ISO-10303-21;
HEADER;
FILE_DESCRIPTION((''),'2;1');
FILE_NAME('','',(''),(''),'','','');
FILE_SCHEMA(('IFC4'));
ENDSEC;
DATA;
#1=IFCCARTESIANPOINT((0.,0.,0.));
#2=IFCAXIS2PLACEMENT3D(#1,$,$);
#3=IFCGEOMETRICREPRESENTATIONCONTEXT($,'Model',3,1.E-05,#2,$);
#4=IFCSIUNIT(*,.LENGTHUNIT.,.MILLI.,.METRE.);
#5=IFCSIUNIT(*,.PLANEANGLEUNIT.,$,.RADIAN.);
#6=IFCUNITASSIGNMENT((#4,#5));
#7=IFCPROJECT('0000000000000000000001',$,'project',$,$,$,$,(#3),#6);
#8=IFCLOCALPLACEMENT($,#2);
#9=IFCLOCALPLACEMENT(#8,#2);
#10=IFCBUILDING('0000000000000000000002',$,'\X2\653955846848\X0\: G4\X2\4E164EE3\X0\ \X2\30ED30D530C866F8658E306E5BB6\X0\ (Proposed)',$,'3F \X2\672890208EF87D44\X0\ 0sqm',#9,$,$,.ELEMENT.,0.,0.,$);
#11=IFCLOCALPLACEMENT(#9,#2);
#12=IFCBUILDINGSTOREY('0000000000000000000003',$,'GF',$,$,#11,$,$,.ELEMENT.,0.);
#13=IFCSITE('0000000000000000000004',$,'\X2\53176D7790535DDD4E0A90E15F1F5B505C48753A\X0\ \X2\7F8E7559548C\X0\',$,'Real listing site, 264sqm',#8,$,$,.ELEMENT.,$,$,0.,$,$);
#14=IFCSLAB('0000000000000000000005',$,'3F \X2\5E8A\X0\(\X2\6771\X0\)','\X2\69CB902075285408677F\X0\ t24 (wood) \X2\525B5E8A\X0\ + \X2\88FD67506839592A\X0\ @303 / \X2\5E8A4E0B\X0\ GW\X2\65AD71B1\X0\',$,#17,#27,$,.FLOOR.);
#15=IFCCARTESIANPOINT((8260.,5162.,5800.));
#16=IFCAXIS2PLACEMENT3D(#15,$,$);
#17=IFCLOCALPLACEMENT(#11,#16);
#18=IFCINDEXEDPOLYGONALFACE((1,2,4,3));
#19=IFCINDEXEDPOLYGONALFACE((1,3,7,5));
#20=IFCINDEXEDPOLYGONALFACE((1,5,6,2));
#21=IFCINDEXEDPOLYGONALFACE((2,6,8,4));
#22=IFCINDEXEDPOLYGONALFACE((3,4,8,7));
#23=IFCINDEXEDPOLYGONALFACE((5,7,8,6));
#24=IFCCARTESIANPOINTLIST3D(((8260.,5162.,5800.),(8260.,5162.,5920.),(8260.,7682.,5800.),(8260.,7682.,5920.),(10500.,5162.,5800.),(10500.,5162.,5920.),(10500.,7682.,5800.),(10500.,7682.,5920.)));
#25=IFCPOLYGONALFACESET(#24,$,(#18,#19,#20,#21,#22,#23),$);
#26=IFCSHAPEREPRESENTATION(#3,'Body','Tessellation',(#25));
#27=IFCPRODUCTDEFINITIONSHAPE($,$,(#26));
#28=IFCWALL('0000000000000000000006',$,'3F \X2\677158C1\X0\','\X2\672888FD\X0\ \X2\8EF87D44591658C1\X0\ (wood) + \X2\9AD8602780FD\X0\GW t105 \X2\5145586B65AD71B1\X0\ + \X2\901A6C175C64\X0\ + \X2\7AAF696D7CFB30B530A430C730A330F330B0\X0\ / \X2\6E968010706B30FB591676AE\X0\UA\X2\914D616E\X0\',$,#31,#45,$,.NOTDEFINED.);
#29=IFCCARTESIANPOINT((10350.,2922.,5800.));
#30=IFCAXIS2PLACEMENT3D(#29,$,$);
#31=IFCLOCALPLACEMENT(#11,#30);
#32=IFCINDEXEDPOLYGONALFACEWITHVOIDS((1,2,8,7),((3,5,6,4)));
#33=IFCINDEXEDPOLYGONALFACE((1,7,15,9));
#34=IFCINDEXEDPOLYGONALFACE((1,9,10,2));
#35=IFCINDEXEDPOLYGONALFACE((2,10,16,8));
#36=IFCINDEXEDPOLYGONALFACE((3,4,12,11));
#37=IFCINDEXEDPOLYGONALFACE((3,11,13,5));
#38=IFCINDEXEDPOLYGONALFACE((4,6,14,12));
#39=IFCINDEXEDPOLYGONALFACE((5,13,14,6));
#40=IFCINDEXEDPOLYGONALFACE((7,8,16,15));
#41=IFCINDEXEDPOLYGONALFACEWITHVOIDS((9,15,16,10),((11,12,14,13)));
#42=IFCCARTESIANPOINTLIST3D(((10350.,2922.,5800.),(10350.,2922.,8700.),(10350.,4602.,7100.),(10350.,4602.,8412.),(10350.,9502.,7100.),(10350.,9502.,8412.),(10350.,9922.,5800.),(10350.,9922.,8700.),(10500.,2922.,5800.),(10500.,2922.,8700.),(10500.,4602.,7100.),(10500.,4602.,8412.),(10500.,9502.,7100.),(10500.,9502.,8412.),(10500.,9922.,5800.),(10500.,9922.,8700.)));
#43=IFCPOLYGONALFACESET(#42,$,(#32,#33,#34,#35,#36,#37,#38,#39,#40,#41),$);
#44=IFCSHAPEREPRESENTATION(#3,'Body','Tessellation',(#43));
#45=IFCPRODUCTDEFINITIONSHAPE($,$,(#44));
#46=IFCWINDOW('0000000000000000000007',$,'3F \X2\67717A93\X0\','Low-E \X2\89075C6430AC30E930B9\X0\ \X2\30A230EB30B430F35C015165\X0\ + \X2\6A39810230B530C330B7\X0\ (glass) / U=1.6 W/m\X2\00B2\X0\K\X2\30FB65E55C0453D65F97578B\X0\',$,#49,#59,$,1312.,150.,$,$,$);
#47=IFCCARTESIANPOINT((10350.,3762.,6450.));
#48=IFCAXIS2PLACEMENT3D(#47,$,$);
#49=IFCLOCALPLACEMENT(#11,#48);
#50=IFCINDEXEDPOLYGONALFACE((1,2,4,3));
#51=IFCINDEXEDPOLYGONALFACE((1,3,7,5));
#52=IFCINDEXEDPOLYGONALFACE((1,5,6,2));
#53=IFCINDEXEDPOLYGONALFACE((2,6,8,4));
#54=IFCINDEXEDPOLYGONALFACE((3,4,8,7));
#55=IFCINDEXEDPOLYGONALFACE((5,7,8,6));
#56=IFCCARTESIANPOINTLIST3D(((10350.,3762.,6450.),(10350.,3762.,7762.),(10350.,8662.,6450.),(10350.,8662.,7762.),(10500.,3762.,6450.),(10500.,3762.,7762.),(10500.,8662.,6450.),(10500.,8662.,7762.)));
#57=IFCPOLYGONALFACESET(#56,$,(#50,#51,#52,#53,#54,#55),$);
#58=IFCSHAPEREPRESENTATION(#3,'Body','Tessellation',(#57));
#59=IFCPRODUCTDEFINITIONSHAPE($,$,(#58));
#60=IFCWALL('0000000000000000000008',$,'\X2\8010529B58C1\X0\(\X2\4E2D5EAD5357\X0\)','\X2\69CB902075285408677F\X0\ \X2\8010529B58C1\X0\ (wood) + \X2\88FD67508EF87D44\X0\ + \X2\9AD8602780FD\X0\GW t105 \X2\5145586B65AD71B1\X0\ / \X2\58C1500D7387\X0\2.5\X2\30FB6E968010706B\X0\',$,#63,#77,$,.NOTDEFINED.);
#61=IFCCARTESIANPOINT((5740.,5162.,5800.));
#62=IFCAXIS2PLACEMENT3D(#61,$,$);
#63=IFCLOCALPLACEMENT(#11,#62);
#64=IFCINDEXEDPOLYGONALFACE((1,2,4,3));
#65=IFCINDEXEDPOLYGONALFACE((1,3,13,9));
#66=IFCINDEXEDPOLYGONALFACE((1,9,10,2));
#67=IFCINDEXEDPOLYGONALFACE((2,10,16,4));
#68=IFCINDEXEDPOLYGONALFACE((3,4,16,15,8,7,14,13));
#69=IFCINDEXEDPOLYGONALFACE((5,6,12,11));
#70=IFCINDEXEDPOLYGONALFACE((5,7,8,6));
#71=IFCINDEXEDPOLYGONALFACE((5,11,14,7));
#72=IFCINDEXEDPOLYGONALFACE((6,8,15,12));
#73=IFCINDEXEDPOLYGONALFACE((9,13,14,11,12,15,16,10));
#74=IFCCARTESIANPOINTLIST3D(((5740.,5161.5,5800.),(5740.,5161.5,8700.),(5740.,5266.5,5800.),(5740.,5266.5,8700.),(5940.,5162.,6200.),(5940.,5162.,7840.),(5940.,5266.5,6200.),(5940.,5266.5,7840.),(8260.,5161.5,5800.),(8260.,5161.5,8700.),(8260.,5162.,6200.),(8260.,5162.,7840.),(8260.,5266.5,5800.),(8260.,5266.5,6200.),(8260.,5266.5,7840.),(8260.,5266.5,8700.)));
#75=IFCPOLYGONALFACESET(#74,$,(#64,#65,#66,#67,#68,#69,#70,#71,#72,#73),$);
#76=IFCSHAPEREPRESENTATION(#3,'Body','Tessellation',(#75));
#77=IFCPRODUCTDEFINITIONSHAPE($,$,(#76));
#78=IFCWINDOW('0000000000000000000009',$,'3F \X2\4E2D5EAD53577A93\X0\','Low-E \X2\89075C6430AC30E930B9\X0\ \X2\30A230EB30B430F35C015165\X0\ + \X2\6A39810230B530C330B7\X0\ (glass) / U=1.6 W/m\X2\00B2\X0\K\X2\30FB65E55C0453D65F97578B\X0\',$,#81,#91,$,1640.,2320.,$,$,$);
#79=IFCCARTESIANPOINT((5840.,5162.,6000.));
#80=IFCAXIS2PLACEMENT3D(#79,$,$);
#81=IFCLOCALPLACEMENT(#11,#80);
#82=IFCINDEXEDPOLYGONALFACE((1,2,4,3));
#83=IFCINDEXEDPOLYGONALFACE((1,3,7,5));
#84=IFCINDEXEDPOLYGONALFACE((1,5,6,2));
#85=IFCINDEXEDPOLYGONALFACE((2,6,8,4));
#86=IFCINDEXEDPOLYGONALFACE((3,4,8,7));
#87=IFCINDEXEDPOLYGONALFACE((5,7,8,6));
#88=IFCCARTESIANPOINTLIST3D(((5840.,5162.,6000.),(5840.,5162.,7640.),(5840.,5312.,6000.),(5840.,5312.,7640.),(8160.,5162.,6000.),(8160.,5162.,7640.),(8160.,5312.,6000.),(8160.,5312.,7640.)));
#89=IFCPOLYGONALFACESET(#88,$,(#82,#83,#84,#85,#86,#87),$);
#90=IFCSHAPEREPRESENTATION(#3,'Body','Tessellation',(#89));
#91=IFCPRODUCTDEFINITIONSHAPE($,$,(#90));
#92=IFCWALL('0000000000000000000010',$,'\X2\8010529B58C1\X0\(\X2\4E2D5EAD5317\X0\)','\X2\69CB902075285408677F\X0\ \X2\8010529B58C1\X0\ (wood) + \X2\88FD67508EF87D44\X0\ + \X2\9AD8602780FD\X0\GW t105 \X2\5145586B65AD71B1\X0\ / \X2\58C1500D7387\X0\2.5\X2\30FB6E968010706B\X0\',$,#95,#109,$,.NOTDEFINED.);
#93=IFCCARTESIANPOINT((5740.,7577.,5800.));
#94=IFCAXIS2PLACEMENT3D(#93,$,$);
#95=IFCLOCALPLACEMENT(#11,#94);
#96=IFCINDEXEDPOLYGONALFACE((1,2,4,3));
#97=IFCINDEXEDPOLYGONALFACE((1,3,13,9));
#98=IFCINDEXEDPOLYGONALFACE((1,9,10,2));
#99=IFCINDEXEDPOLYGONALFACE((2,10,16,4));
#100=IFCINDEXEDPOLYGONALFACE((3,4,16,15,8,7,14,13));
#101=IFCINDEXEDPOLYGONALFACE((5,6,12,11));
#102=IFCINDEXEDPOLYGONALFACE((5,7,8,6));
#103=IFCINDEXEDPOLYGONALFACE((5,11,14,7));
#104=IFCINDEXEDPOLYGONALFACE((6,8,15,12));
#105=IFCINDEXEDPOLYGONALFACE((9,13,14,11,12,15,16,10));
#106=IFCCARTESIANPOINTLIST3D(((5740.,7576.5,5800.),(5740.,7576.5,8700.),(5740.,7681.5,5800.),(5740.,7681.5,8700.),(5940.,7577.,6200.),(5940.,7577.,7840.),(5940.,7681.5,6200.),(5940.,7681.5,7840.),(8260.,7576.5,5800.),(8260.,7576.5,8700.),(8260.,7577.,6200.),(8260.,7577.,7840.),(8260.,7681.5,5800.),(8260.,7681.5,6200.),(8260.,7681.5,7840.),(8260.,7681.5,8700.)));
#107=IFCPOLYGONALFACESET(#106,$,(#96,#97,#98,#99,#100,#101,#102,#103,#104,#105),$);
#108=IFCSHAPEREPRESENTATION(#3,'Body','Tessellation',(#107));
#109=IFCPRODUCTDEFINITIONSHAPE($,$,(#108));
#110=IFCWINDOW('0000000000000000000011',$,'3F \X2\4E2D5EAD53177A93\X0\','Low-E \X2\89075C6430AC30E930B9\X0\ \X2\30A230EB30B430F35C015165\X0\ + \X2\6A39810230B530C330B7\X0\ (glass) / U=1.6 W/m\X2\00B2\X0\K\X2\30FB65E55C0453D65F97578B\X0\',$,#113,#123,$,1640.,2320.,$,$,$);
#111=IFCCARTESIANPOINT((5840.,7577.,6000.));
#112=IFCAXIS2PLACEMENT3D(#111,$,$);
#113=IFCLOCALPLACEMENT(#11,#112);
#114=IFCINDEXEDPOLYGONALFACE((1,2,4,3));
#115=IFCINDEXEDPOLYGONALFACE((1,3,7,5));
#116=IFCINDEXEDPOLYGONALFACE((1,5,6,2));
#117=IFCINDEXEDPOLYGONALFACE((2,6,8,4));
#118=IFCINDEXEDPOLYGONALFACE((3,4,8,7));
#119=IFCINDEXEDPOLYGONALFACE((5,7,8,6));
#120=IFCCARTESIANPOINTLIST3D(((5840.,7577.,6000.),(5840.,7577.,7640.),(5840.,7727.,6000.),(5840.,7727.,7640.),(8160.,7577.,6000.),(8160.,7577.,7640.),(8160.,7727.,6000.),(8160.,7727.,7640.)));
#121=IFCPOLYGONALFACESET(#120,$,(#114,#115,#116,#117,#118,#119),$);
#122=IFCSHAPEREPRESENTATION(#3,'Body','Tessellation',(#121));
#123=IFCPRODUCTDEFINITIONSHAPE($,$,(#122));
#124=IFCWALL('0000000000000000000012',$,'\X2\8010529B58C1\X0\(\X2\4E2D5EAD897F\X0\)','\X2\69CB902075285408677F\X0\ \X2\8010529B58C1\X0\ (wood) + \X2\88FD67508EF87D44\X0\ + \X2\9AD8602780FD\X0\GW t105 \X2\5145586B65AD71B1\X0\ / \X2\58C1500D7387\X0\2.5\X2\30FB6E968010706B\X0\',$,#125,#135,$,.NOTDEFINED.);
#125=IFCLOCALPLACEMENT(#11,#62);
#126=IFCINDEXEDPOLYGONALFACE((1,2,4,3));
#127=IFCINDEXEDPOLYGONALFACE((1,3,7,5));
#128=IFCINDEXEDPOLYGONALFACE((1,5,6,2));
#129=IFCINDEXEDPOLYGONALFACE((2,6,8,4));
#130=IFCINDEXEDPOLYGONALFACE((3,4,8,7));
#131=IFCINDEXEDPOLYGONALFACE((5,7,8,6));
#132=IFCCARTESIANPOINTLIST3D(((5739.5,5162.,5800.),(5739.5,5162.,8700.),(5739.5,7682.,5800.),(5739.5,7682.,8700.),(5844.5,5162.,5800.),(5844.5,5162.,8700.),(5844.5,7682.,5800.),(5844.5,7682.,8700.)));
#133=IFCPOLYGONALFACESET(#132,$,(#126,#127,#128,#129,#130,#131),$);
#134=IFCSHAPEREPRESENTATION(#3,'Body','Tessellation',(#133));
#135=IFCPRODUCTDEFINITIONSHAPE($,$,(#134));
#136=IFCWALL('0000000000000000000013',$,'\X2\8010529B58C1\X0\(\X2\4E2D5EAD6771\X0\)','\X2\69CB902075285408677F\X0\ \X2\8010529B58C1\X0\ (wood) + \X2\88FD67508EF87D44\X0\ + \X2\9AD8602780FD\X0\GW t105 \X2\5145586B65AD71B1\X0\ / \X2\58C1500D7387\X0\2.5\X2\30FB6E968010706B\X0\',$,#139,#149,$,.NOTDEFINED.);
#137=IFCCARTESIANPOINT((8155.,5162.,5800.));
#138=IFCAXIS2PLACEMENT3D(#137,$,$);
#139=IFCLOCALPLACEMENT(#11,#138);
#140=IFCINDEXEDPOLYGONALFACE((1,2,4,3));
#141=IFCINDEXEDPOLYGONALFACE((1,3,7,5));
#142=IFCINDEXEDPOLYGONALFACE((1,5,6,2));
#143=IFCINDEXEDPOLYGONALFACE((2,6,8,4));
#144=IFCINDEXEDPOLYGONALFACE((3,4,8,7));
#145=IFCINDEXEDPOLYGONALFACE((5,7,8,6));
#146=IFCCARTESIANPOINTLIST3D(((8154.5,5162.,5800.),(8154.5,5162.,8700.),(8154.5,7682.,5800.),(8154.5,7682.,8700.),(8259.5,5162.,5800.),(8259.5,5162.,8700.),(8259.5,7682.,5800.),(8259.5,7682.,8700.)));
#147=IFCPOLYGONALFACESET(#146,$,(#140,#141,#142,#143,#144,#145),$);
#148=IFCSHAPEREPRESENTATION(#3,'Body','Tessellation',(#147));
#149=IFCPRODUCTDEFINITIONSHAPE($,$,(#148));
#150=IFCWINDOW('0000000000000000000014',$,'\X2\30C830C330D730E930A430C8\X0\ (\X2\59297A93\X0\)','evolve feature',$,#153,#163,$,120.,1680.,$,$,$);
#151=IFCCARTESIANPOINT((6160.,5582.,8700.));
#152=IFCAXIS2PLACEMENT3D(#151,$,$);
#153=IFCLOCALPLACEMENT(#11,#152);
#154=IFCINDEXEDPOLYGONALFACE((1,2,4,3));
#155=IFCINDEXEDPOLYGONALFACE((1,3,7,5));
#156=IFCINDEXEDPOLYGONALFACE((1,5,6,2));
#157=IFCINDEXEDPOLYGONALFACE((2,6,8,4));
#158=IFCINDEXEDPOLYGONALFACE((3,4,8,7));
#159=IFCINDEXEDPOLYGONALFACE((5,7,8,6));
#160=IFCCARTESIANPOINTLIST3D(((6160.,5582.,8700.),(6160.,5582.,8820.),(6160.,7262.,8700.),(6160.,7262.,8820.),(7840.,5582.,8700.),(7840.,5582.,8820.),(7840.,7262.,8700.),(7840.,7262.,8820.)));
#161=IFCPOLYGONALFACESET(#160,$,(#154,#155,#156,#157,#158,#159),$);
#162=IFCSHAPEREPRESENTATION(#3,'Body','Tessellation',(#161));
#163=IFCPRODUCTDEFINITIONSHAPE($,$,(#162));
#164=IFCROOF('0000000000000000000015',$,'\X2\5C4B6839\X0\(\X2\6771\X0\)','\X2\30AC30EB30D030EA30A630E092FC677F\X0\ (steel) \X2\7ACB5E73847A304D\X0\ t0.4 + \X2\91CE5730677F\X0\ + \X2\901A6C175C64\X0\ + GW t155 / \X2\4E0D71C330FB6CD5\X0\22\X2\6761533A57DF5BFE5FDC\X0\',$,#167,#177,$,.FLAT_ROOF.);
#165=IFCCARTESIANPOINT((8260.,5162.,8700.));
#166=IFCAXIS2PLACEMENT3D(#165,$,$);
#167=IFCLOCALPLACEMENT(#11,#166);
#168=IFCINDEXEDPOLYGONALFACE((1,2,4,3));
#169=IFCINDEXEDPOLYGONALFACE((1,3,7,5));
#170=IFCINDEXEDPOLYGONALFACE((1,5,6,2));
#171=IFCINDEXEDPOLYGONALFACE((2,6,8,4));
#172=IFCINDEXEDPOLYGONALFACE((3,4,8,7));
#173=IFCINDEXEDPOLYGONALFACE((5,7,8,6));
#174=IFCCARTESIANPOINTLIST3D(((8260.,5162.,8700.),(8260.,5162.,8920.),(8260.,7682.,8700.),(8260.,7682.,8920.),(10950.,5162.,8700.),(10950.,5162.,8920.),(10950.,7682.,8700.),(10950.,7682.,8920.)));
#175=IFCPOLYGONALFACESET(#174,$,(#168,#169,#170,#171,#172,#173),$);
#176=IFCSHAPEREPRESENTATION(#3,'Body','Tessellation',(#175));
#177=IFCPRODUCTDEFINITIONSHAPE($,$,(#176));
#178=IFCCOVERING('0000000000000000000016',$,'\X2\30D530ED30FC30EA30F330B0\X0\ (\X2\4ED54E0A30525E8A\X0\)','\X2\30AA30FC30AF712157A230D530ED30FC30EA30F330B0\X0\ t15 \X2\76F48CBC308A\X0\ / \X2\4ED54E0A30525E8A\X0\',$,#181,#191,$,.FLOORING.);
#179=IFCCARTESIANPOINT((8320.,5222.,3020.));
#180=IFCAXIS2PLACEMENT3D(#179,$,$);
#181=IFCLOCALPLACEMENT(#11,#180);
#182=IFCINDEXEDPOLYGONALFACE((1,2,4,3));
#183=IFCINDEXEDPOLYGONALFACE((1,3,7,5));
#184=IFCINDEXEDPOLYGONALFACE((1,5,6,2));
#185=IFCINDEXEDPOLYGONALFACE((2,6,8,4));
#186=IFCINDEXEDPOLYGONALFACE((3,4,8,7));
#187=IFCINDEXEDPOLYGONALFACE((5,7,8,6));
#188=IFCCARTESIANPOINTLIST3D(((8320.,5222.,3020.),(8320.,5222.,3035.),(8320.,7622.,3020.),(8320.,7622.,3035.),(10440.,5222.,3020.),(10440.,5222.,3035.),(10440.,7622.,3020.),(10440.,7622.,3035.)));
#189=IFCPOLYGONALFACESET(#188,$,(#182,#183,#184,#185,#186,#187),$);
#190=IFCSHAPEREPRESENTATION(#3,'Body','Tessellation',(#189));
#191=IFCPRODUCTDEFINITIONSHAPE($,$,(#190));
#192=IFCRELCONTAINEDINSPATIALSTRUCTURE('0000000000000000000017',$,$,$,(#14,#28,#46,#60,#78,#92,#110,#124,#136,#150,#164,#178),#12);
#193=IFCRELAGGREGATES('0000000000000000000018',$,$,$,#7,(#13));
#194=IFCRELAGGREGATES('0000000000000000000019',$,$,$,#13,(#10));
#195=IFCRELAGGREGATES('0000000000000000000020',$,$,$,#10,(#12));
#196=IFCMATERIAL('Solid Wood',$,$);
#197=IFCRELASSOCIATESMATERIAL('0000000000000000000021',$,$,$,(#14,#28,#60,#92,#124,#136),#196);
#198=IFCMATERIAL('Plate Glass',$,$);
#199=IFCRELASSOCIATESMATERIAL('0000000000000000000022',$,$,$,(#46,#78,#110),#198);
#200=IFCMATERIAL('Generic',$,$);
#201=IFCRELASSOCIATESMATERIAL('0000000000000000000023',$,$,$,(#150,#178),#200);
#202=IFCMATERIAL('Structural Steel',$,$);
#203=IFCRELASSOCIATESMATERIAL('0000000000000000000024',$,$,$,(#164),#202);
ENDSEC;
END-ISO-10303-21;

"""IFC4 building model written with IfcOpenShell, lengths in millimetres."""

from ifc_helpers import new_model, si_unit, frame, frame_2d, origin, place, context, project, spatial, rectangle, extrude, material, element, fill, save


model = new_model("IFC4")

# Units and contexts
model_context = context("Model", 3, precision=1e-05, world=origin())
ifc_project = project(units=[si_unit("LENGTHUNIT", "METRE", prefix="MILLI"), si_unit("PLANEANGLEUNIT", "RADIAN")], contexts=[model_context])

# Site, building, storey
site_placement = place(None, origin())
site = spatial("IfcSite", under=ifc_project, at=site_placement, Name="北海道川上郡弟子屈町 美留和", ObjectType="Real listing site, 264sqm", CompositionType="ELEMENT", RefElevation=0.0)
building_placement = place(site_placement, origin())
building = spatial("IfcBuilding", under=site, at=building_placement, Name="改善案: G4世代 ロフト書斎の家 (Proposed)", ObjectType="3F 木造軸組 0sqm", CompositionType="ELEMENT", ElevationOfRefHeight=0.0, ElevationOfTerrain=0.0)
storey_placement = place(building_placement, origin())
storey = spatial("IfcBuildingStorey", under=building, at=storey_placement, Name="GF", CompositionType="ELEMENT", Elevation=0.0)

# Slab
ifc_material_1 = material(Name="Solid Wood")
slab_placement = place(storey_placement, frame((8260.0, 5162.0, 5800.0)))
element("IfcSlab", 1, at=slab_placement, inside=storey, material=ifc_material_1, Name="3F 床(東)", Description="構造用合板 t24 (wood) 剛床 + 製材根太 @303 / 床下 GW断熱", PredefinedType="FLOOR", context=model_context, shape_type="SweptSolid", body=[
    extrude(rectangle(XDim=2240.0, YDim=2520.0, at=frame_2d((1120.0, 1260.0))), frame((8260.0, 5162.0, 5800.0)), (0.0, 0.0, 1.0), 120.0),
])

# Walls, openings, windows
wall_1_placement = place(storey_placement, frame((10350.0, 2922.0, 5800.0)))
wall_1 = element("IfcWall", 2, at=wall_1_placement, inside=storey, material=ifc_material_1, Name="3F 東壁", Description="木製 軸組外壁 (wood) + 高性能GW t105 充填断熱 + 通気層 + 窯業系サイディング / 準耐火・外皮UA配慮", PredefinedType="NOTDEFINED", context=model_context, shape_type="SweptSolid", body=[
    extrude(rectangle(XDim=150.0, YDim=7000.0, at=frame_2d((75.0, 3500.0))), frame((10350.0, 2922.0, 5800.0)), (0.0, 0.0, 1.0), 2900.0),
])
opening_1_placement = place(storey_placement, frame((10350.0, 3762.0, 6450.0)))
opening_1 = element("IfcOpeningElement", 3, at=opening_1_placement, cuts=wall_1, PredefinedType="NOTDEFINED", context=model_context, shape_type="SweptSolid", body=[
    extrude(rectangle(XDim=150.0, YDim=4900.0, at=frame_2d((75.0, 2450.0))), frame((10350.0, 3762.0, 6450.0)), (0.0, 0.0, 1.0), 1312.0),
])
ifc_material_2 = material(Name="Plate Glass")
window_1_placement = place(storey_placement, frame((10350.0, 3762.0, 6450.0)))
window_1 = element("IfcWindow", 4, at=window_1_placement, inside=storey, material=ifc_material_2, Name="3F 東窓", Description="Low-E 複層ガラス アルゴン封入 + 樹脂サッシ (glass) / U=1.6 W/m²K・日射取得型", OverallHeight=1312.0, OverallWidth=150.0, context=model_context, shape_type="SweptSolid", body=[
    extrude(rectangle(XDim=150.0, YDim=4900.0, at=frame_2d((75.0, 2450.0))), frame((10350.0, 3762.0, 6450.0)), (0.0, 0.0, 1.0), 1312.0),
])
fill(opening_1, window_1)
wall_2_placement = place(storey_placement, frame((5740.0, 5162.0, 5800.0)))
wall_2 = element("IfcWall", 5, at=wall_2_placement, inside=storey, material=ifc_material_1, Name="耐力壁(中庭南)", Description="構造用合板 耐力壁 (wood) + 製材軸組 + 高性能GW t105 充填断熱 / 壁倍率2.5・準耐火", PredefinedType="NOTDEFINED", context=model_context, shape_type="SweptSolid", body=[
    extrude(rectangle(XDim=2520.0, YDim=105.0, at=frame_2d((1260.0, 52.0))), frame((5740.0, 5162.0, 5800.0)), (0.0, 0.0, 1.0), 2900.0),
])
opening_2_placement = place(storey_placement, frame((5840.0, 5162.0, 6000.0)))
opening_2 = element("IfcOpeningElement", 6, at=opening_2_placement, cuts=wall_2, PredefinedType="NOTDEFINED", context=model_context, shape_type="SweptSolid", body=[
    extrude(rectangle(XDim=2320.0, YDim=150.0, at=frame_2d((1160.0, 75.0))), frame((5840.0, 5162.0, 6000.0)), (0.0, 0.0, 1.0), 1640.0),
])
window_2_placement = place(storey_placement, frame((5840.0, 5162.0, 6000.0)))
window_2 = element("IfcWindow", 7, at=window_2_placement, inside=storey, material=ifc_material_2, Name="3F 中庭南窓", Description="Low-E 複層ガラス アルゴン封入 + 樹脂サッシ (glass) / U=1.6 W/m²K・日射取得型", OverallHeight=1640.0, OverallWidth=2320.0, context=model_context, shape_type="SweptSolid", body=[
    extrude(rectangle(XDim=2320.0, YDim=150.0, at=frame_2d((1160.0, 75.0))), frame((5840.0, 5162.0, 6000.0)), (0.0, 0.0, 1.0), 1640.0),
])
fill(opening_2, window_2)
wall_3_placement = place(storey_placement, frame((5740.0, 7577.0, 5800.0)))
wall_3 = element("IfcWall", 8, at=wall_3_placement, inside=storey, material=ifc_material_1, Name="耐力壁(中庭北)", Description="構造用合板 耐力壁 (wood) + 製材軸組 + 高性能GW t105 充填断熱 / 壁倍率2.5・準耐火", PredefinedType="NOTDEFINED", context=model_context, shape_type="SweptSolid", body=[
    extrude(rectangle(XDim=2520.0, YDim=105.0, at=frame_2d((1260.0, 52.0))), frame((5740.0, 7577.0, 5800.0)), (0.0, 0.0, 1.0), 2900.0),
])
opening_3_placement = place(storey_placement, frame((5840.0, 7577.0, 6000.0)))
opening_3 = element("IfcOpeningElement", 9, at=opening_3_placement, cuts=wall_3, PredefinedType="NOTDEFINED", context=model_context, shape_type="SweptSolid", body=[
    extrude(rectangle(XDim=2320.0, YDim=150.0, at=frame_2d((1160.0, 75.0))), frame((5840.0, 7577.0, 6000.0)), (0.0, 0.0, 1.0), 1640.0),
])
window_3_placement = place(storey_placement, frame((5840.0, 7577.0, 6000.0)))
window_3 = element("IfcWindow", 10, at=window_3_placement, inside=storey, material=ifc_material_2, Name="3F 中庭北窓", Description="Low-E 複層ガラス アルゴン封入 + 樹脂サッシ (glass) / U=1.6 W/m²K・日射取得型", OverallHeight=1640.0, OverallWidth=2320.0, context=model_context, shape_type="SweptSolid", body=[
    extrude(rectangle(XDim=2320.0, YDim=150.0, at=frame_2d((1160.0, 75.0))), frame((5840.0, 7577.0, 6000.0)), (0.0, 0.0, 1.0), 1640.0),
])
fill(opening_3, window_3)

# Walls
wall_4_placement = place(storey_placement, frame((5740.0, 5162.0, 5800.0)))
element("IfcWall", 11, at=wall_4_placement, inside=storey, material=ifc_material_1, Name="耐力壁(中庭西)", Description="構造用合板 耐力壁 (wood) + 製材軸組 + 高性能GW t105 充填断熱 / 壁倍率2.5・準耐火", PredefinedType="NOTDEFINED", context=model_context, shape_type="SweptSolid", body=[
    extrude(rectangle(XDim=105.0, YDim=2520.0, at=frame_2d((52.0, 1260.0))), frame((5740.0, 5162.0, 5800.0)), (0.0, 0.0, 1.0), 2900.0),
])
wall_5_placement = place(storey_placement, frame((8155.0, 5162.0, 5800.0)))
element("IfcWall", 12, at=wall_5_placement, inside=storey, material=ifc_material_1, Name="耐力壁(中庭東)", Description="構造用合板 耐力壁 (wood) + 製材軸組 + 高性能GW t105 充填断熱 / 壁倍率2.5・準耐火", PredefinedType="NOTDEFINED", context=model_context, shape_type="SweptSolid", body=[
    extrude(rectangle(XDim=105.0, YDim=2520.0, at=frame_2d((52.0, 1260.0))), frame((8155.0, 5162.0, 5800.0)), (0.0, 0.0, 1.0), 2900.0),
])

# Window
ifc_material_3 = material(Name="Generic")
window_4_placement = place(storey_placement, frame((6160.0, 5582.0, 8700.0)))
element("IfcWindow", 13, at=window_4_placement, inside=storey, material=ifc_material_3, Name="トップライト (天窓)", Description="evolve feature", OverallHeight=120.0, OverallWidth=1680.0, context=model_context, shape_type="SweptSolid", body=[
    extrude(rectangle(XDim=1680.0, YDim=1680.0, at=frame_2d((840.0, 840.0))), frame((6160.0, 5582.0, 8700.0)), (0.0, 0.0, 1.0), 120.0),
])

# Roof
ifc_material_4 = material(Name="Structural Steel")
for number, where, name in (
    (14, (8260.0, 5162.0, 8700.0), "屋根(東)"),
):
    element("IfcRoof", number, at=place(storey_placement, frame(where)), inside=storey, material=ifc_material_4, Name=name, Description="ガルバリウム鋼板 (steel) 立平葺き t0.4 + 野地板 + 通気層 + GW t155 / 不燃・法22条区域対応", PredefinedType="FLAT_ROOF", context=model_context, shape_type="SweptSolid", body=[
        extrude(rectangle(XDim=2690.0, YDim=2520.0, at=frame_2d((1345.0, 1260.0))), frame((8260.0, 5162.0, 8700.0)), (0.0, 0.0, 1.0), 220.0),
    ])

# Covering
covering_1_placement = place(storey_placement, frame((8320.0, 5222.0, 3020.0)))
element("IfcCovering", 15, at=covering_1_placement, inside=storey, material=ifc_material_3, Name="フローリング (仕上げ床)", Description="オーク無垢フローリング t15 直貼り / 仕上げ床", PredefinedType="FLOORING", context=model_context, shape_type="SweptSolid", body=[
    extrude(rectangle(XDim=2120.0, YDim=2400.0, at=frame_2d((1060.0, 1200.0))), frame((8320.0, 5222.0, 3020.0)), (0.0, 0.0, 1.0), 15.0),
])

save(model, "model.ifc")
